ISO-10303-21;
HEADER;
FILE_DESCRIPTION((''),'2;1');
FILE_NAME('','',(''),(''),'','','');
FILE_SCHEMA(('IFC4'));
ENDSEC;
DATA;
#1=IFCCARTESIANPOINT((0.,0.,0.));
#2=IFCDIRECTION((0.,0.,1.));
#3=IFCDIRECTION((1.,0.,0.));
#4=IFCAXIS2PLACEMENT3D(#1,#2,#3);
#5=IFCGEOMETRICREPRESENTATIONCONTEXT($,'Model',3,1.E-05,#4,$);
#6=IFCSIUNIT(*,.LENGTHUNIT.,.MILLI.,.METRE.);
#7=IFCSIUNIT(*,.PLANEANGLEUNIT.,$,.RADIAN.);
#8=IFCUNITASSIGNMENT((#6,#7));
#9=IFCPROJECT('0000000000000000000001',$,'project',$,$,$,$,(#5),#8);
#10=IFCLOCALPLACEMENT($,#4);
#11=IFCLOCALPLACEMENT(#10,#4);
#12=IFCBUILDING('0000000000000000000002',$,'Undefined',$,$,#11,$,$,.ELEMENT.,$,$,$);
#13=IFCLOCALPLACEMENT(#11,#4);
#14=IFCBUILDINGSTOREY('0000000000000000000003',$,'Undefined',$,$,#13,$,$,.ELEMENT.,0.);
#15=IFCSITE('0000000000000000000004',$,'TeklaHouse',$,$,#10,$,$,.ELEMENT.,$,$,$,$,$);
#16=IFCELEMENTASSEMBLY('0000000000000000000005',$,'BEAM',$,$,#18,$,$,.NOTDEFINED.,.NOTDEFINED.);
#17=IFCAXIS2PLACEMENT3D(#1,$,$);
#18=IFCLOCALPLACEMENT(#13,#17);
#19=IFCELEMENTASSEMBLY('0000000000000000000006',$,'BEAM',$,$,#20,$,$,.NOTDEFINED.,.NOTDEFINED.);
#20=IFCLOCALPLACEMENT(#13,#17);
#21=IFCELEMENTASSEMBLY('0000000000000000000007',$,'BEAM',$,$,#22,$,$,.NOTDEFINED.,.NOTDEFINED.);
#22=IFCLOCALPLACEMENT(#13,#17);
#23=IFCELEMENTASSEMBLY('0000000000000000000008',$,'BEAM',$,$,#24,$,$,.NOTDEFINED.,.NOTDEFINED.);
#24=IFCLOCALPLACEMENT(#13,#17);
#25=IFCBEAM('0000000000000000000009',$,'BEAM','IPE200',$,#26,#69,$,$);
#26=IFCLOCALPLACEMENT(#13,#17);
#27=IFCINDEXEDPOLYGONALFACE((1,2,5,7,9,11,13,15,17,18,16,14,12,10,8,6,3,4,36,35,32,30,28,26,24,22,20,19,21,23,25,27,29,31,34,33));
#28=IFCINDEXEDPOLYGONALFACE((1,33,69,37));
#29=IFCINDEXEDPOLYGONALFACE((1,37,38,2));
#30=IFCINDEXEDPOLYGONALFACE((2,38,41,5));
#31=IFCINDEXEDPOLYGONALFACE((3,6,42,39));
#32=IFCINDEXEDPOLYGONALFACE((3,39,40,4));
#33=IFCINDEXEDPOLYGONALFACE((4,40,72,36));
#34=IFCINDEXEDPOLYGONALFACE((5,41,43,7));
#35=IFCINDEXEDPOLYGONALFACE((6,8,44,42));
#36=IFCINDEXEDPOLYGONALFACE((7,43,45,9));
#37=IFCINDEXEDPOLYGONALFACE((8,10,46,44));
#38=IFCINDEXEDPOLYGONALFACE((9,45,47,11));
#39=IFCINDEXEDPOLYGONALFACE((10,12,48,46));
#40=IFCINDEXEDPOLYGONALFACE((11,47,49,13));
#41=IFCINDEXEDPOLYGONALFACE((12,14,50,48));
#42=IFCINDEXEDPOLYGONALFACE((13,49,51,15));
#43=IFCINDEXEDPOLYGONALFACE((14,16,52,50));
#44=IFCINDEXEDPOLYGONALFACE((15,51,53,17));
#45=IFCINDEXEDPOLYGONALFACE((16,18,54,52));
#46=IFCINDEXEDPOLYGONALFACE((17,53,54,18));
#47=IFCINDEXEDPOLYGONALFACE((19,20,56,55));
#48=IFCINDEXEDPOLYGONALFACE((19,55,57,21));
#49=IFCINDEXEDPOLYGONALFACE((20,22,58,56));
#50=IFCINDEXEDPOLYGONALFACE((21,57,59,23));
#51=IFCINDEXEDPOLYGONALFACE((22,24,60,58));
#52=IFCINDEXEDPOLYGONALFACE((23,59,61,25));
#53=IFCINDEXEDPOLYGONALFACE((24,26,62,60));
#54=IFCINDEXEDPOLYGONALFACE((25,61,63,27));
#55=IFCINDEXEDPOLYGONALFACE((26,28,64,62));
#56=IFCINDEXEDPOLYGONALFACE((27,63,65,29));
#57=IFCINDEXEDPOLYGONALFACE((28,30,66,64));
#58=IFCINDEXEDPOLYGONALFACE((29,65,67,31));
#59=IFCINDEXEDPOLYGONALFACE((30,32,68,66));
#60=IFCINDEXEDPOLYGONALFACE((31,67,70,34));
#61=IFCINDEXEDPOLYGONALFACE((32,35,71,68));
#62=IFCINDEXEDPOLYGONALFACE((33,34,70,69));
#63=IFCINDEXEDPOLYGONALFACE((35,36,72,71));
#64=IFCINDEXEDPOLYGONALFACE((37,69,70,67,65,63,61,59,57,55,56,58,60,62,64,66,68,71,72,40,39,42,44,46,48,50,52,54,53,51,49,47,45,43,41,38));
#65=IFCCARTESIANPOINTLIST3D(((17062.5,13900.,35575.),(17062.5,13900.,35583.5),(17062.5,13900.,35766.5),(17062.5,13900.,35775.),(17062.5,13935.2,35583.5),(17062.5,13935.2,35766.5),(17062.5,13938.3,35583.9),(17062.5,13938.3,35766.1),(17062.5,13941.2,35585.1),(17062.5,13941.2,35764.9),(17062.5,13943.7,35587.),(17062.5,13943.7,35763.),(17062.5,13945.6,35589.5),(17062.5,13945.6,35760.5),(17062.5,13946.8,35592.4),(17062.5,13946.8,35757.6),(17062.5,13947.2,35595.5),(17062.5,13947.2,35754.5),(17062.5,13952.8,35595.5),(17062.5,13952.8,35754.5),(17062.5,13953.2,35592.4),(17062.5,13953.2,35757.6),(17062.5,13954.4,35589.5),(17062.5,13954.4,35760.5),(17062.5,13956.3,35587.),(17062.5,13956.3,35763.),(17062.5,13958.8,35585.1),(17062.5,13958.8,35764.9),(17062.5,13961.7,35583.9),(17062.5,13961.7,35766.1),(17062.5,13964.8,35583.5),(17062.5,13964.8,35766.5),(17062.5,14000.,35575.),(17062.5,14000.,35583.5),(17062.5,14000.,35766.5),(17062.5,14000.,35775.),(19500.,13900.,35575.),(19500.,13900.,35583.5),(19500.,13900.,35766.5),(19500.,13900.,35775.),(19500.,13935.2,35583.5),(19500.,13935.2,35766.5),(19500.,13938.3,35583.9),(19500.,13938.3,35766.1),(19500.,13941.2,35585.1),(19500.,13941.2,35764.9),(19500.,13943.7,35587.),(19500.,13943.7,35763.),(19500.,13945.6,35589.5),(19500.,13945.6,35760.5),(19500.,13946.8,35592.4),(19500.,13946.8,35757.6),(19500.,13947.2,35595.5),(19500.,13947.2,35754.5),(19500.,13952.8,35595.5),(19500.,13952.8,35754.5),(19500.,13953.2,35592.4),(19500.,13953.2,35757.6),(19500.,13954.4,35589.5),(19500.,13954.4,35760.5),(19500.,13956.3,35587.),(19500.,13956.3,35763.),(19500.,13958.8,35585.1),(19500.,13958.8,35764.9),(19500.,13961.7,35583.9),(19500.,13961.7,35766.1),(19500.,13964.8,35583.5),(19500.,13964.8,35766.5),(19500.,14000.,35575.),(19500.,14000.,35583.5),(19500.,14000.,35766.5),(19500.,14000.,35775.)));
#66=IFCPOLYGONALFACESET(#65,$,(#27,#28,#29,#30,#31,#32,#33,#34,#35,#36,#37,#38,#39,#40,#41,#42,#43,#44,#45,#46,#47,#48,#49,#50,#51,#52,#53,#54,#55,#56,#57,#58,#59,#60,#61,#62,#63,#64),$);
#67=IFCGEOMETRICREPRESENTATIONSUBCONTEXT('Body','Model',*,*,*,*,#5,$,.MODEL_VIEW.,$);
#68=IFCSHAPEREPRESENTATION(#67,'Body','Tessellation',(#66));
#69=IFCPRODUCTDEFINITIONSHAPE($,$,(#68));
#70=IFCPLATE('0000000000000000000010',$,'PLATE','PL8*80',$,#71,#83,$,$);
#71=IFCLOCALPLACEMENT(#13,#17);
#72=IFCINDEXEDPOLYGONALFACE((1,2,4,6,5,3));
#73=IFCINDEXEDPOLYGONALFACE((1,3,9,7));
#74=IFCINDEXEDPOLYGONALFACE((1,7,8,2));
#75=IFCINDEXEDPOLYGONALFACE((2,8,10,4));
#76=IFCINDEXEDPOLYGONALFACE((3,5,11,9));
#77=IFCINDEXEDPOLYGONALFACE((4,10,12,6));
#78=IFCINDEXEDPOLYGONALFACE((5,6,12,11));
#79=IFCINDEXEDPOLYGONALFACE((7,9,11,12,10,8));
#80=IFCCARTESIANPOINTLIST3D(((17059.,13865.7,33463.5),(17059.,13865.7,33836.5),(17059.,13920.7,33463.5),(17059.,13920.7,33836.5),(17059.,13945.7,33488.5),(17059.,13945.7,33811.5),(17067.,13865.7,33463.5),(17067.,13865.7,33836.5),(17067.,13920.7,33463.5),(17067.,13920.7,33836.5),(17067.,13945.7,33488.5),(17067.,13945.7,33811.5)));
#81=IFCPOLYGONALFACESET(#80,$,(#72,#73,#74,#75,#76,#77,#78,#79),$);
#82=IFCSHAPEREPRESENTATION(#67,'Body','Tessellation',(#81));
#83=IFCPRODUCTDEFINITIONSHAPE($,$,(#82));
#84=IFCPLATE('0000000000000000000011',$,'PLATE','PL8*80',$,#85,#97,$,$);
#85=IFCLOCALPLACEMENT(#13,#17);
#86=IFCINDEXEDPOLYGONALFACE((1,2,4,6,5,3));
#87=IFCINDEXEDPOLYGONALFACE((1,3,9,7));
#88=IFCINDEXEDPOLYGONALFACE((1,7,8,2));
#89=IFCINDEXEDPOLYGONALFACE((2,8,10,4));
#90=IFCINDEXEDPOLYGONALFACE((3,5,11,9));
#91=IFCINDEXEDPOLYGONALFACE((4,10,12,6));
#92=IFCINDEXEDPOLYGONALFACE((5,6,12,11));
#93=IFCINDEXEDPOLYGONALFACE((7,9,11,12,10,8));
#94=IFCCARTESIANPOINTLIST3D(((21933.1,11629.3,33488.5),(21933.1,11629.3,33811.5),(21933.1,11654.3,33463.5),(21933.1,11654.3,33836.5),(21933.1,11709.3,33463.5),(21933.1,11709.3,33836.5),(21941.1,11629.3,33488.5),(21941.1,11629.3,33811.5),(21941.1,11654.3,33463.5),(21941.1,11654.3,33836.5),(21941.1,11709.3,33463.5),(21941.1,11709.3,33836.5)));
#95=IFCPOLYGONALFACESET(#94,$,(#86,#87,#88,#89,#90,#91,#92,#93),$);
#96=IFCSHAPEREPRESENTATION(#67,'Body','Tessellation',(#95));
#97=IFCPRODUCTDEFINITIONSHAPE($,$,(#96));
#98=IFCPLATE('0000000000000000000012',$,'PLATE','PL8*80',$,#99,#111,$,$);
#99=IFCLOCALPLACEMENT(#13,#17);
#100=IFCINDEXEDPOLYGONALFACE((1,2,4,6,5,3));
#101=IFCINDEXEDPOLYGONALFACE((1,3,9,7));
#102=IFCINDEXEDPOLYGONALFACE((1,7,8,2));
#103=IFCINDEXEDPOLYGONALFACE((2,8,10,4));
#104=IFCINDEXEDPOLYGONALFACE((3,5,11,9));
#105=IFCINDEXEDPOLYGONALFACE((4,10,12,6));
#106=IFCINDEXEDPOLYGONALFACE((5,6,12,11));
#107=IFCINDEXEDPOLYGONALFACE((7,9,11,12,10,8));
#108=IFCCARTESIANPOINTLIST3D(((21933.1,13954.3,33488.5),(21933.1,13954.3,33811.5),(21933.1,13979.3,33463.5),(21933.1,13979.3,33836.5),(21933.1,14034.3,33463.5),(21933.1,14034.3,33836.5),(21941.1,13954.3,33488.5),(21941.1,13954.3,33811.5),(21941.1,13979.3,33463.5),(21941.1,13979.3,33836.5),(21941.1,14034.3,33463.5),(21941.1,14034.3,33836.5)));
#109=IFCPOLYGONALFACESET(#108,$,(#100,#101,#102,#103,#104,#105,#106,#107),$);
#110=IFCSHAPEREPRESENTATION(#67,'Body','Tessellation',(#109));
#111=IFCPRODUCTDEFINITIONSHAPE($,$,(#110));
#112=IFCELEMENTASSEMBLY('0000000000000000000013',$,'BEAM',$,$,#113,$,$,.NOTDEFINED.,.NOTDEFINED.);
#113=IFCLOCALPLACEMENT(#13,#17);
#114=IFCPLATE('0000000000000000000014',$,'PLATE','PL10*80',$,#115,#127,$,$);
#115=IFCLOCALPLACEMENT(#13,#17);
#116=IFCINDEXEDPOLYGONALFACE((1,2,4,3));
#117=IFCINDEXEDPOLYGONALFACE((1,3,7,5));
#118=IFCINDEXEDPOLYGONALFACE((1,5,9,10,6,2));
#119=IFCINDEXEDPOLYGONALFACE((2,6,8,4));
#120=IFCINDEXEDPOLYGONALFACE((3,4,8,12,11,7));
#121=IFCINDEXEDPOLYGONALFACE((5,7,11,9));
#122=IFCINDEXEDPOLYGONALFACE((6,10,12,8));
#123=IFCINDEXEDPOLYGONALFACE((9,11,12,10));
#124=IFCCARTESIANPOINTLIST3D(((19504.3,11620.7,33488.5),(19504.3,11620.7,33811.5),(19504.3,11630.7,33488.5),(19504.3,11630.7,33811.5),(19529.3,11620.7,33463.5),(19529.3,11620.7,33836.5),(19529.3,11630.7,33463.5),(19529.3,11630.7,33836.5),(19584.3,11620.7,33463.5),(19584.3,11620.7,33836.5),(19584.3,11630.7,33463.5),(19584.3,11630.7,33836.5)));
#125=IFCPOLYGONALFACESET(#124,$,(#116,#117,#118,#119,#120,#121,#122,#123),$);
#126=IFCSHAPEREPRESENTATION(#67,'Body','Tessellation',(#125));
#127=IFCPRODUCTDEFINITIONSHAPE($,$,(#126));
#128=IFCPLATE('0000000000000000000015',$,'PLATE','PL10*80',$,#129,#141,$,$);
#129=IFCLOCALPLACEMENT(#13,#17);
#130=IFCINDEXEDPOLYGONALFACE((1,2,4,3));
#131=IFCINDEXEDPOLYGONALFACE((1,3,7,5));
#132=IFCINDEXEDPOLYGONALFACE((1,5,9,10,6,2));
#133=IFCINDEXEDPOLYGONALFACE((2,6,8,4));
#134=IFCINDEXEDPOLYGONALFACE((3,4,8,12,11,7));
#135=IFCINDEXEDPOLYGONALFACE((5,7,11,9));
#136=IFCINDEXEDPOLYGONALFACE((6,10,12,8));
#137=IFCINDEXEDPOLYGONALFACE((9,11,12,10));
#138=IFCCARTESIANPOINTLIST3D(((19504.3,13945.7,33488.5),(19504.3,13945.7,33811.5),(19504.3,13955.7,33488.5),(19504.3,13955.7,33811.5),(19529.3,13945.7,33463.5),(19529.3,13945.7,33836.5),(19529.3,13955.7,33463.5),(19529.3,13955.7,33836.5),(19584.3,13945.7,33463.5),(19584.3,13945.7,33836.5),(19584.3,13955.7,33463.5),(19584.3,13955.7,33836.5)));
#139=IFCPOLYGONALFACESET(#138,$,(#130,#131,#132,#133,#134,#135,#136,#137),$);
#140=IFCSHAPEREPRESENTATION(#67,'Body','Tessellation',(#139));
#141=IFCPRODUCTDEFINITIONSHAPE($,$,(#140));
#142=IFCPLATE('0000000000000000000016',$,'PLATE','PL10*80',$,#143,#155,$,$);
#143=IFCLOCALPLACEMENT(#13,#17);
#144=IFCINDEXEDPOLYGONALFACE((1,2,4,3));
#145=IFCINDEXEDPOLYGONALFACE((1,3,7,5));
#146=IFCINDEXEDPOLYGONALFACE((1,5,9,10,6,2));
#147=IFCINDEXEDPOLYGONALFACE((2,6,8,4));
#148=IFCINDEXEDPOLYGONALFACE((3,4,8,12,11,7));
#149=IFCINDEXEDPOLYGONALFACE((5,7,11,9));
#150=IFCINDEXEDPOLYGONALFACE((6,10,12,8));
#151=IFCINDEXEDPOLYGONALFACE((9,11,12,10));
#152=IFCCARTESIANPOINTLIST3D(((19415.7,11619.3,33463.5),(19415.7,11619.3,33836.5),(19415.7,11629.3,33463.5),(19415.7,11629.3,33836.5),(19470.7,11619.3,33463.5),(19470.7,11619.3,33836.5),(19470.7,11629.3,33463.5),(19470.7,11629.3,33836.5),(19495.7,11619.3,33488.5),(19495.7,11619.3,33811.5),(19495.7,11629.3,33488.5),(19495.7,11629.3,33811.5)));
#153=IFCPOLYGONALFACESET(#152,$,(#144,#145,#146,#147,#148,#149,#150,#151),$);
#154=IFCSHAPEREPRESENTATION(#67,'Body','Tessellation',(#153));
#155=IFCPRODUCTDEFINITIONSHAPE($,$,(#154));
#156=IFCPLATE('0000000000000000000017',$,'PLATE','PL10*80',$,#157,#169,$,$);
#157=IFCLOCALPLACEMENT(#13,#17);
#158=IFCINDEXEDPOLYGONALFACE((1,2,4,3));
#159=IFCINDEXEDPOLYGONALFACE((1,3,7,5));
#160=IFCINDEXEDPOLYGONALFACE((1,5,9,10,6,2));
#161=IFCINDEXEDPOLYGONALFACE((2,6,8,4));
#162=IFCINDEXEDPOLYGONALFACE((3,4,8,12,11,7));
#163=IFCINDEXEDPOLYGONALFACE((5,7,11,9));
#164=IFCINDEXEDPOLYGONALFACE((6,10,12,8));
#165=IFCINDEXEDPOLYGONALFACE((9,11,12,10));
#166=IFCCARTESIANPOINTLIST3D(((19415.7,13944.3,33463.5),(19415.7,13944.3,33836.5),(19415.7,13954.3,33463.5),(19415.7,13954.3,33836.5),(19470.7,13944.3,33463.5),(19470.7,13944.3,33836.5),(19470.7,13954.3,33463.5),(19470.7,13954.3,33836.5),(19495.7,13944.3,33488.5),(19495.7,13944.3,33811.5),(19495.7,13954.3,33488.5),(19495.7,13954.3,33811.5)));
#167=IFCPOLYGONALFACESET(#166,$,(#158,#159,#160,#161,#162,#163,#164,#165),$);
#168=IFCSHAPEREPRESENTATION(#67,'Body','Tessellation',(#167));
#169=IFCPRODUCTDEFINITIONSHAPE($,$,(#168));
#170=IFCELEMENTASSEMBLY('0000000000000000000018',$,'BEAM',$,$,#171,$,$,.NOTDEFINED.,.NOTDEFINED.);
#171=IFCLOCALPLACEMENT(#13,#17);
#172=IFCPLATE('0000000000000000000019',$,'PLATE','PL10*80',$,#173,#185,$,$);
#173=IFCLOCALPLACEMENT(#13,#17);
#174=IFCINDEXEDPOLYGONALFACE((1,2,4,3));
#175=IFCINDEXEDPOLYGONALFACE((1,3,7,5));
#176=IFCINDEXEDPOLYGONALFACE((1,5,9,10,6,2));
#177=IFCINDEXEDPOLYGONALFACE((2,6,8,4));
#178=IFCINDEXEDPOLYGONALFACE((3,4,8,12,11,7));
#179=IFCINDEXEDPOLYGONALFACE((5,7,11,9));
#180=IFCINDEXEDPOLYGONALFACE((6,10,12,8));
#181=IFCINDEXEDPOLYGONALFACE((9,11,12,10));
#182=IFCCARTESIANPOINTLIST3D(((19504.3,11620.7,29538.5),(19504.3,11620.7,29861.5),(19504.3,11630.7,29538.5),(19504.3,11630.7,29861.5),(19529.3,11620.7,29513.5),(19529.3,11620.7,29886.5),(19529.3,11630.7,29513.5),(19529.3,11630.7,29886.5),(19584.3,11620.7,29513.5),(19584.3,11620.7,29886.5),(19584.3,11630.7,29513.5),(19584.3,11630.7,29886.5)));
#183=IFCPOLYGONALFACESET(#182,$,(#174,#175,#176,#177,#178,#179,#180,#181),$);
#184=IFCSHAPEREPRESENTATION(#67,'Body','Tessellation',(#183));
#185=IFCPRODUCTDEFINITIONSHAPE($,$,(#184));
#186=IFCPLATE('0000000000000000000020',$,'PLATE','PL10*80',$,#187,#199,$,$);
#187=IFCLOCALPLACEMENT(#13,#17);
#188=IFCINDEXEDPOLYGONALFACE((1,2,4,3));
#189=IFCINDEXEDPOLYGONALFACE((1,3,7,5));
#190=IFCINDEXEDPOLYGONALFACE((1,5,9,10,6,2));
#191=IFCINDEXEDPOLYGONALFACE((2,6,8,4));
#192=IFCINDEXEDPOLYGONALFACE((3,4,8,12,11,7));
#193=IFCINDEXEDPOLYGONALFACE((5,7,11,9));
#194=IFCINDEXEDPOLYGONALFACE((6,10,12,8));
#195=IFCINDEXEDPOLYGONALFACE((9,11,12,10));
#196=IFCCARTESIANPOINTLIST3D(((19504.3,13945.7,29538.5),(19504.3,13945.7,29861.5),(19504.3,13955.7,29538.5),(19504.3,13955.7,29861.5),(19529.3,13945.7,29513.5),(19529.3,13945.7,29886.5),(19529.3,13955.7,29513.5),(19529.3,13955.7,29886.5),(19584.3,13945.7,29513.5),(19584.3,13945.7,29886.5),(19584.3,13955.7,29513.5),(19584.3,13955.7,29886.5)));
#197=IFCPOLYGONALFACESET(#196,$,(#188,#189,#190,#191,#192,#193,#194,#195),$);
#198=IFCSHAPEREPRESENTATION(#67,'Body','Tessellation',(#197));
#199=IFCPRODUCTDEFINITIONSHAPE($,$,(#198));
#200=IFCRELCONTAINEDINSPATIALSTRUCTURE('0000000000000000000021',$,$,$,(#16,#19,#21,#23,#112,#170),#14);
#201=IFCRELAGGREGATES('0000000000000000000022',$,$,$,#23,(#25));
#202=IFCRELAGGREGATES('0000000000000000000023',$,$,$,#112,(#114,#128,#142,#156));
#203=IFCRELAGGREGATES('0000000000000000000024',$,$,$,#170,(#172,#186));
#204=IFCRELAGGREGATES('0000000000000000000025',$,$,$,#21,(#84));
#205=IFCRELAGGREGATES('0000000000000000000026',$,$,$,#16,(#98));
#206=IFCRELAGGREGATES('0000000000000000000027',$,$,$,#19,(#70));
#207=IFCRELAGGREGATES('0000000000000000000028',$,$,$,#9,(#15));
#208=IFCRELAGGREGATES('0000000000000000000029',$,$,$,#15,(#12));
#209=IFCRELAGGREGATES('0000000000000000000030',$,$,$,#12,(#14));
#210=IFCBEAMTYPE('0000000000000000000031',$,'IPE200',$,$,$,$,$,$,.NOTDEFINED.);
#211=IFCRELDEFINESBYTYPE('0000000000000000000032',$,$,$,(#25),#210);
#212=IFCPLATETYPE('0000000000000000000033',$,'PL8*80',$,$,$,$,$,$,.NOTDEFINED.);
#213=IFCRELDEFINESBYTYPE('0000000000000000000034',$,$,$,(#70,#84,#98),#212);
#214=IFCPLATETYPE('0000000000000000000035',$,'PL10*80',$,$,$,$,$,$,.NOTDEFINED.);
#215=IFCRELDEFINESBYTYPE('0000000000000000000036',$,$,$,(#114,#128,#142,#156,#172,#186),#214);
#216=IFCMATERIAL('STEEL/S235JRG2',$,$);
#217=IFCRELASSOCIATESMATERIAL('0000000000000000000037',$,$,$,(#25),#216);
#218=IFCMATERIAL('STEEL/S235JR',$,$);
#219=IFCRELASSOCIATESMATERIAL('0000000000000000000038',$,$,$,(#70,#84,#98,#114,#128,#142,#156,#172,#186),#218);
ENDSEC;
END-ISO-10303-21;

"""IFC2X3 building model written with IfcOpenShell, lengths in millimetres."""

from ifc_helpers import new_model, si_unit, frame, origin_with_axes, origin_2d_with_axis, place, context, subcontext, project, spatial, polyline, i_section, outline, extrude, material, type_object, element, aggregate, save


model = new_model("IFC2X3")

# Units and contexts
model_context = context("Model", 3, precision=1e-05, world=origin_with_axes())
body_context = subcontext(model_context, "Body", "Model", "MODEL_VIEW")
ifc_project = project(units=[si_unit("LENGTHUNIT", "METRE", prefix="MILLI"), si_unit("PLANEANGLEUNIT", "RADIAN")], contexts=[model_context])

# Site, building, storey
site_placement = place(None, origin_with_axes())
site = spatial("IfcSite", under=ifc_project, at=site_placement, Name="TeklaHouse", CompositionType="ELEMENT")
building_placement = place(site_placement, origin_with_axes())
building = spatial("IfcBuilding", under=site, at=building_placement, Name="Undefined", CompositionType="ELEMENT")
storey_placement = place(building_placement, origin_with_axes())
storey = spatial("IfcBuildingStorey", under=building, at=storey_placement, Name="Undefined", CompositionType="ELEMENT", Elevation=0.0)

# Shared definitions
ifc_material_1 = material(Name="STEEL/S235JRG2")

# Element assemblies
ifc_material_2 = material(Name="STEEL/S235JR")
assembly_1_placement = place(storey_placement, origin_with_axes())
assembly_1 = element("IfcElementAssembly", 1, at=assembly_1_placement, inside=storey, Name="BEAM", AssemblyPlace="NOTDEFINED", PredefinedType="NOTDEFINED")
assembly_2_placement = place(storey_placement, origin_with_axes())
assembly_2 = element("IfcElementAssembly", 2, at=assembly_2_placement, inside=storey, Name="BEAM", AssemblyPlace="NOTDEFINED", PredefinedType="NOTDEFINED")
assembly_3_placement = place(storey_placement, origin_with_axes())
assembly_3 = element("IfcElementAssembly", 3, at=assembly_3_placement, inside=storey, Name="BEAM", AssemblyPlace="NOTDEFINED", PredefinedType="NOTDEFINED")

# Element assembly, beam
beam_type_1 = type_object("IfcBeamType", Name="IPE200", PredefinedType="NOTDEFINED")
assembly_4_placement = place(storey_placement, origin_with_axes())
assembly_4 = element("IfcElementAssembly", 4, at=assembly_4_placement, inside=storey, Name="BEAM", AssemblyPlace="NOTDEFINED", PredefinedType="NOTDEFINED")
beam_1_placement = place(assembly_4_placement, frame((17062.5, 13950.0, 35675.0), z_axis=(0.0, 0.0, 1.0), x_axis=(1.0, 0.0, 0.0)))
beam_1 = element("IfcBeam", 5, at=beam_1_placement, type_object=beam_type_1, material=ifc_material_1, Name="BEAM", Description="IPE200", context=body_context, shape_type="SweptSolid", body=[
    extrude(i_section(OverallWidth=100.0, OverallDepth=200.0, WebThickness=5.6, FlangeThickness=8.5, FilletRadius=12.0, at=origin_2d_with_axis()), frame((2437.5, 0.0, 0.0), z_axis=(-1.0, 0.0, 0.0), x_axis=(0.0, -1.0, 0.0)), (0.0, 0.0, 1.0), 2437.5),
])
aggregate(assembly_4, [beam_1])

# Plates
plate_type_1 = type_object("IfcPlateType", Name="PL8*80", PredefinedType="NOTDEFINED")
plate_1_placement = place(assembly_2_placement, frame((17063.0, 13945.7, 33463.5), z_axis=(-1.0, 0.0, 0.0), x_axis=(0.0, -1.0, 0.0)))
plate_1 = element("IfcPlate", 6, at=plate_1_placement, type_object=plate_type_1, material=ifc_material_2, Name="PLATE", Description="PL8*80", context=body_context, shape_type="SweptSolid", body=[
    extrude(outline(polyline([(0.0, 25.0), (25.0, 0.0), (80.0, 0.0), (80.0, 373.0), (25.0, 373.0), (0.0, 348.0), (0.0, 25.0)])), frame((0.0, 0.0, -4.0), z_axis=(0.0, 0.0, 1.0), x_axis=(1.0, 0.0, 0.0)), (0.0, 0.0, 1.0), 8.0),
])
plate_2_placement = place(assembly_3_placement, frame((21937.1, 11629.3, 33463.5), z_axis=(1.0, 0.0, 0.0), x_axis=(0.0, 1.0, 0.0)))
plate_2 = element("IfcPlate", 7, at=plate_2_placement, type_object=plate_type_1, material=ifc_material_2, Name="PLATE", Description="PL8*80", context=body_context, shape_type="SweptSolid", body=[
    extrude(outline(polyline([(0.0, 25.0), (25.0, 0.0), (80.0, 0.0), (80.0, 373.0), (25.0, 373.0), (0.0, 348.0), (0.0, 25.0)])), frame((0.0, 0.0, -4.0), z_axis=(0.0, 0.0, 1.0), x_axis=(1.0, 0.0, 0.0)), (0.0, 0.0, 1.0), 8.0),
])
plate_3_placement = place(assembly_1_placement, frame((21937.1, 13954.3, 33463.5), z_axis=(1.0, 0.0, 0.0), x_axis=(0.0, 1.0, 0.0)))
plate_3 = element("IfcPlate", 8, at=plate_3_placement, type_object=plate_type_1, material=ifc_material_2, Name="PLATE", Description="PL8*80", context=body_context, shape_type="SweptSolid", body=[
    extrude(outline(polyline([(0.0, 25.0), (25.0, 0.0), (80.0, 0.0), (80.0, 373.0), (25.0, 373.0), (0.0, 348.0), (0.0, 25.0)])), frame((0.0, 0.0, -4.0), z_axis=(0.0, 0.0, 1.0), x_axis=(1.0, 0.0, 0.0)), (0.0, 0.0, 1.0), 8.0),
])

# Element assemblies, plates
assembly_5_placement = place(storey_placement, origin_with_axes())
assembly_5 = element("IfcElementAssembly", 9, at=assembly_5_placement, inside=storey, Name="BEAM", AssemblyPlace="NOTDEFINED", PredefinedType="NOTDEFINED")
plate_type_2 = type_object("IfcPlateType", Name="PL10*80", PredefinedType="NOTDEFINED")
plate_4_placement = place(assembly_5_placement, frame((19504.3, 11625.7, 33463.5), z_axis=(0.0, -1.0, 0.0), x_axis=(1.0, 0.0, 0.0)))
plate_4 = element("IfcPlate", 10, at=plate_4_placement, type_object=plate_type_2, material=ifc_material_2, Name="PLATE", Description="PL10*80", context=body_context, shape_type="SweptSolid", body=[
    extrude(outline(polyline([(0.0, 25.0), (25.0, 0.0), (80.0, 0.0), (80.0, 373.0), (25.0, 373.0), (0.0, 348.0), (0.0, 25.0)])), frame((0.0, 0.0, -5.0), z_axis=(0.0, 0.0, 1.0), x_axis=(1.0, 0.0, 0.0)), (0.0, 0.0, 1.0), 10.0),
])
plate_5_placement = place(assembly_5_placement, frame((19504.3, 13950.7, 33463.5), z_axis=(0.0, -1.0, 0.0), x_axis=(1.0, 0.0, 0.0)))
plate_5 = element("IfcPlate", 11, at=plate_5_placement, type_object=plate_type_2, material=ifc_material_2, Name="PLATE", Description="PL10*80", context=body_context, shape_type="SweptSolid", body=[
    extrude(outline(polyline([(0.0, 25.0), (25.0, 0.0), (80.0, 0.0), (80.0, 373.0), (25.0, 373.0), (0.0, 348.0), (0.0, 25.0)])), frame((0.0, 0.0, -5.0), z_axis=(0.0, 0.0, 1.0), x_axis=(1.0, 0.0, 0.0)), (0.0, 0.0, 1.0), 10.0),
])
plate_6_placement = place(assembly_5_placement, frame((19495.7, 11624.3, 33463.5), z_axis=(0.0, 1.0, 0.0), x_axis=(-1.0, 0.0, 0.0)))
plate_6 = element("IfcPlate", 12, at=plate_6_placement, type_object=plate_type_2, material=ifc_material_2, Name="PLATE", Description="PL10*80", context=body_context, shape_type="SweptSolid", body=[
    extrude(outline(polyline([(0.0, 25.0), (25.0, 0.0), (80.0, 0.0), (80.0, 373.0), (25.0, 373.0), (0.0, 348.0), (0.0, 25.0)])), frame((0.0, 0.0, -5.0), z_axis=(0.0, 0.0, 1.0), x_axis=(1.0, 0.0, 0.0)), (0.0, 0.0, 1.0), 10.0),
])
plate_7_placement = place(assembly_5_placement, frame((19495.7, 13949.3, 33463.5), z_axis=(0.0, 1.0, 0.0), x_axis=(-1.0, 0.0, 0.0)))
plate_7 = element("IfcPlate", 13, at=plate_7_placement, type_object=plate_type_2, material=ifc_material_2, Name="PLATE", Description="PL10*80", context=body_context, shape_type="SweptSolid", body=[
    extrude(outline(polyline([(0.0, 25.0), (25.0, 0.0), (80.0, 0.0), (80.0, 373.0), (25.0, 373.0), (0.0, 348.0), (0.0, 25.0)])), frame((0.0, 0.0, -5.0), z_axis=(0.0, 0.0, 1.0), x_axis=(1.0, 0.0, 0.0)), (0.0, 0.0, 1.0), 10.0),
])
aggregate(assembly_5, [plate_4, plate_5, plate_6, plate_7])
assembly_6_placement = place(storey_placement, origin_with_axes())
assembly_6 = element("IfcElementAssembly", 14, at=assembly_6_placement, inside=storey, Name="BEAM", AssemblyPlace="NOTDEFINED", PredefinedType="NOTDEFINED")
plate_8_placement = place(assembly_6_placement, frame((19504.3, 11625.7, 29513.5), z_axis=(0.0, -1.0, 0.0), x_axis=(1.0, 0.0, 0.0)))
plate_8 = element("IfcPlate", 15, at=plate_8_placement, type_object=plate_type_2, material=ifc_material_2, Name="PLATE", Description="PL10*80", context=body_context, shape_type="SweptSolid", body=[
    extrude(outline(polyline([(0.0, 25.0), (25.0, 0.0), (80.0, 0.0), (80.0, 373.0), (25.0, 373.0), (0.0, 348.0), (0.0, 25.0)])), frame((0.0, 0.0, -5.0), z_axis=(0.0, 0.0, 1.0), x_axis=(1.0, 0.0, 0.0)), (0.0, 0.0, 1.0), 10.0),
])
plate_9_placement = place(assembly_6_placement, frame((19504.3, 13950.7, 29513.5), z_axis=(0.0, -1.0, 0.0), x_axis=(1.0, 0.0, 0.0)))
plate_9 = element("IfcPlate", 16, at=plate_9_placement, type_object=plate_type_2, material=ifc_material_2, Name="PLATE", Description="PL10*80", context=body_context, shape_type="SweptSolid", body=[
    extrude(outline(polyline([(0.0, 25.0), (25.0, 0.0), (80.0, 0.0), (80.0, 373.0), (25.0, 373.0), (0.0, 348.0), (0.0, 25.0)])), frame((0.0, 0.0, -5.0), z_axis=(0.0, 0.0, 1.0), x_axis=(1.0, 0.0, 0.0)), (0.0, 0.0, 1.0), 10.0),
])
aggregate(assembly_6, [plate_8, plate_9])

aggregate(assembly_3, [plate_2])
aggregate(assembly_1, [plate_3])
aggregate(assembly_2, [plate_1])

save(model, "model.ifc")
